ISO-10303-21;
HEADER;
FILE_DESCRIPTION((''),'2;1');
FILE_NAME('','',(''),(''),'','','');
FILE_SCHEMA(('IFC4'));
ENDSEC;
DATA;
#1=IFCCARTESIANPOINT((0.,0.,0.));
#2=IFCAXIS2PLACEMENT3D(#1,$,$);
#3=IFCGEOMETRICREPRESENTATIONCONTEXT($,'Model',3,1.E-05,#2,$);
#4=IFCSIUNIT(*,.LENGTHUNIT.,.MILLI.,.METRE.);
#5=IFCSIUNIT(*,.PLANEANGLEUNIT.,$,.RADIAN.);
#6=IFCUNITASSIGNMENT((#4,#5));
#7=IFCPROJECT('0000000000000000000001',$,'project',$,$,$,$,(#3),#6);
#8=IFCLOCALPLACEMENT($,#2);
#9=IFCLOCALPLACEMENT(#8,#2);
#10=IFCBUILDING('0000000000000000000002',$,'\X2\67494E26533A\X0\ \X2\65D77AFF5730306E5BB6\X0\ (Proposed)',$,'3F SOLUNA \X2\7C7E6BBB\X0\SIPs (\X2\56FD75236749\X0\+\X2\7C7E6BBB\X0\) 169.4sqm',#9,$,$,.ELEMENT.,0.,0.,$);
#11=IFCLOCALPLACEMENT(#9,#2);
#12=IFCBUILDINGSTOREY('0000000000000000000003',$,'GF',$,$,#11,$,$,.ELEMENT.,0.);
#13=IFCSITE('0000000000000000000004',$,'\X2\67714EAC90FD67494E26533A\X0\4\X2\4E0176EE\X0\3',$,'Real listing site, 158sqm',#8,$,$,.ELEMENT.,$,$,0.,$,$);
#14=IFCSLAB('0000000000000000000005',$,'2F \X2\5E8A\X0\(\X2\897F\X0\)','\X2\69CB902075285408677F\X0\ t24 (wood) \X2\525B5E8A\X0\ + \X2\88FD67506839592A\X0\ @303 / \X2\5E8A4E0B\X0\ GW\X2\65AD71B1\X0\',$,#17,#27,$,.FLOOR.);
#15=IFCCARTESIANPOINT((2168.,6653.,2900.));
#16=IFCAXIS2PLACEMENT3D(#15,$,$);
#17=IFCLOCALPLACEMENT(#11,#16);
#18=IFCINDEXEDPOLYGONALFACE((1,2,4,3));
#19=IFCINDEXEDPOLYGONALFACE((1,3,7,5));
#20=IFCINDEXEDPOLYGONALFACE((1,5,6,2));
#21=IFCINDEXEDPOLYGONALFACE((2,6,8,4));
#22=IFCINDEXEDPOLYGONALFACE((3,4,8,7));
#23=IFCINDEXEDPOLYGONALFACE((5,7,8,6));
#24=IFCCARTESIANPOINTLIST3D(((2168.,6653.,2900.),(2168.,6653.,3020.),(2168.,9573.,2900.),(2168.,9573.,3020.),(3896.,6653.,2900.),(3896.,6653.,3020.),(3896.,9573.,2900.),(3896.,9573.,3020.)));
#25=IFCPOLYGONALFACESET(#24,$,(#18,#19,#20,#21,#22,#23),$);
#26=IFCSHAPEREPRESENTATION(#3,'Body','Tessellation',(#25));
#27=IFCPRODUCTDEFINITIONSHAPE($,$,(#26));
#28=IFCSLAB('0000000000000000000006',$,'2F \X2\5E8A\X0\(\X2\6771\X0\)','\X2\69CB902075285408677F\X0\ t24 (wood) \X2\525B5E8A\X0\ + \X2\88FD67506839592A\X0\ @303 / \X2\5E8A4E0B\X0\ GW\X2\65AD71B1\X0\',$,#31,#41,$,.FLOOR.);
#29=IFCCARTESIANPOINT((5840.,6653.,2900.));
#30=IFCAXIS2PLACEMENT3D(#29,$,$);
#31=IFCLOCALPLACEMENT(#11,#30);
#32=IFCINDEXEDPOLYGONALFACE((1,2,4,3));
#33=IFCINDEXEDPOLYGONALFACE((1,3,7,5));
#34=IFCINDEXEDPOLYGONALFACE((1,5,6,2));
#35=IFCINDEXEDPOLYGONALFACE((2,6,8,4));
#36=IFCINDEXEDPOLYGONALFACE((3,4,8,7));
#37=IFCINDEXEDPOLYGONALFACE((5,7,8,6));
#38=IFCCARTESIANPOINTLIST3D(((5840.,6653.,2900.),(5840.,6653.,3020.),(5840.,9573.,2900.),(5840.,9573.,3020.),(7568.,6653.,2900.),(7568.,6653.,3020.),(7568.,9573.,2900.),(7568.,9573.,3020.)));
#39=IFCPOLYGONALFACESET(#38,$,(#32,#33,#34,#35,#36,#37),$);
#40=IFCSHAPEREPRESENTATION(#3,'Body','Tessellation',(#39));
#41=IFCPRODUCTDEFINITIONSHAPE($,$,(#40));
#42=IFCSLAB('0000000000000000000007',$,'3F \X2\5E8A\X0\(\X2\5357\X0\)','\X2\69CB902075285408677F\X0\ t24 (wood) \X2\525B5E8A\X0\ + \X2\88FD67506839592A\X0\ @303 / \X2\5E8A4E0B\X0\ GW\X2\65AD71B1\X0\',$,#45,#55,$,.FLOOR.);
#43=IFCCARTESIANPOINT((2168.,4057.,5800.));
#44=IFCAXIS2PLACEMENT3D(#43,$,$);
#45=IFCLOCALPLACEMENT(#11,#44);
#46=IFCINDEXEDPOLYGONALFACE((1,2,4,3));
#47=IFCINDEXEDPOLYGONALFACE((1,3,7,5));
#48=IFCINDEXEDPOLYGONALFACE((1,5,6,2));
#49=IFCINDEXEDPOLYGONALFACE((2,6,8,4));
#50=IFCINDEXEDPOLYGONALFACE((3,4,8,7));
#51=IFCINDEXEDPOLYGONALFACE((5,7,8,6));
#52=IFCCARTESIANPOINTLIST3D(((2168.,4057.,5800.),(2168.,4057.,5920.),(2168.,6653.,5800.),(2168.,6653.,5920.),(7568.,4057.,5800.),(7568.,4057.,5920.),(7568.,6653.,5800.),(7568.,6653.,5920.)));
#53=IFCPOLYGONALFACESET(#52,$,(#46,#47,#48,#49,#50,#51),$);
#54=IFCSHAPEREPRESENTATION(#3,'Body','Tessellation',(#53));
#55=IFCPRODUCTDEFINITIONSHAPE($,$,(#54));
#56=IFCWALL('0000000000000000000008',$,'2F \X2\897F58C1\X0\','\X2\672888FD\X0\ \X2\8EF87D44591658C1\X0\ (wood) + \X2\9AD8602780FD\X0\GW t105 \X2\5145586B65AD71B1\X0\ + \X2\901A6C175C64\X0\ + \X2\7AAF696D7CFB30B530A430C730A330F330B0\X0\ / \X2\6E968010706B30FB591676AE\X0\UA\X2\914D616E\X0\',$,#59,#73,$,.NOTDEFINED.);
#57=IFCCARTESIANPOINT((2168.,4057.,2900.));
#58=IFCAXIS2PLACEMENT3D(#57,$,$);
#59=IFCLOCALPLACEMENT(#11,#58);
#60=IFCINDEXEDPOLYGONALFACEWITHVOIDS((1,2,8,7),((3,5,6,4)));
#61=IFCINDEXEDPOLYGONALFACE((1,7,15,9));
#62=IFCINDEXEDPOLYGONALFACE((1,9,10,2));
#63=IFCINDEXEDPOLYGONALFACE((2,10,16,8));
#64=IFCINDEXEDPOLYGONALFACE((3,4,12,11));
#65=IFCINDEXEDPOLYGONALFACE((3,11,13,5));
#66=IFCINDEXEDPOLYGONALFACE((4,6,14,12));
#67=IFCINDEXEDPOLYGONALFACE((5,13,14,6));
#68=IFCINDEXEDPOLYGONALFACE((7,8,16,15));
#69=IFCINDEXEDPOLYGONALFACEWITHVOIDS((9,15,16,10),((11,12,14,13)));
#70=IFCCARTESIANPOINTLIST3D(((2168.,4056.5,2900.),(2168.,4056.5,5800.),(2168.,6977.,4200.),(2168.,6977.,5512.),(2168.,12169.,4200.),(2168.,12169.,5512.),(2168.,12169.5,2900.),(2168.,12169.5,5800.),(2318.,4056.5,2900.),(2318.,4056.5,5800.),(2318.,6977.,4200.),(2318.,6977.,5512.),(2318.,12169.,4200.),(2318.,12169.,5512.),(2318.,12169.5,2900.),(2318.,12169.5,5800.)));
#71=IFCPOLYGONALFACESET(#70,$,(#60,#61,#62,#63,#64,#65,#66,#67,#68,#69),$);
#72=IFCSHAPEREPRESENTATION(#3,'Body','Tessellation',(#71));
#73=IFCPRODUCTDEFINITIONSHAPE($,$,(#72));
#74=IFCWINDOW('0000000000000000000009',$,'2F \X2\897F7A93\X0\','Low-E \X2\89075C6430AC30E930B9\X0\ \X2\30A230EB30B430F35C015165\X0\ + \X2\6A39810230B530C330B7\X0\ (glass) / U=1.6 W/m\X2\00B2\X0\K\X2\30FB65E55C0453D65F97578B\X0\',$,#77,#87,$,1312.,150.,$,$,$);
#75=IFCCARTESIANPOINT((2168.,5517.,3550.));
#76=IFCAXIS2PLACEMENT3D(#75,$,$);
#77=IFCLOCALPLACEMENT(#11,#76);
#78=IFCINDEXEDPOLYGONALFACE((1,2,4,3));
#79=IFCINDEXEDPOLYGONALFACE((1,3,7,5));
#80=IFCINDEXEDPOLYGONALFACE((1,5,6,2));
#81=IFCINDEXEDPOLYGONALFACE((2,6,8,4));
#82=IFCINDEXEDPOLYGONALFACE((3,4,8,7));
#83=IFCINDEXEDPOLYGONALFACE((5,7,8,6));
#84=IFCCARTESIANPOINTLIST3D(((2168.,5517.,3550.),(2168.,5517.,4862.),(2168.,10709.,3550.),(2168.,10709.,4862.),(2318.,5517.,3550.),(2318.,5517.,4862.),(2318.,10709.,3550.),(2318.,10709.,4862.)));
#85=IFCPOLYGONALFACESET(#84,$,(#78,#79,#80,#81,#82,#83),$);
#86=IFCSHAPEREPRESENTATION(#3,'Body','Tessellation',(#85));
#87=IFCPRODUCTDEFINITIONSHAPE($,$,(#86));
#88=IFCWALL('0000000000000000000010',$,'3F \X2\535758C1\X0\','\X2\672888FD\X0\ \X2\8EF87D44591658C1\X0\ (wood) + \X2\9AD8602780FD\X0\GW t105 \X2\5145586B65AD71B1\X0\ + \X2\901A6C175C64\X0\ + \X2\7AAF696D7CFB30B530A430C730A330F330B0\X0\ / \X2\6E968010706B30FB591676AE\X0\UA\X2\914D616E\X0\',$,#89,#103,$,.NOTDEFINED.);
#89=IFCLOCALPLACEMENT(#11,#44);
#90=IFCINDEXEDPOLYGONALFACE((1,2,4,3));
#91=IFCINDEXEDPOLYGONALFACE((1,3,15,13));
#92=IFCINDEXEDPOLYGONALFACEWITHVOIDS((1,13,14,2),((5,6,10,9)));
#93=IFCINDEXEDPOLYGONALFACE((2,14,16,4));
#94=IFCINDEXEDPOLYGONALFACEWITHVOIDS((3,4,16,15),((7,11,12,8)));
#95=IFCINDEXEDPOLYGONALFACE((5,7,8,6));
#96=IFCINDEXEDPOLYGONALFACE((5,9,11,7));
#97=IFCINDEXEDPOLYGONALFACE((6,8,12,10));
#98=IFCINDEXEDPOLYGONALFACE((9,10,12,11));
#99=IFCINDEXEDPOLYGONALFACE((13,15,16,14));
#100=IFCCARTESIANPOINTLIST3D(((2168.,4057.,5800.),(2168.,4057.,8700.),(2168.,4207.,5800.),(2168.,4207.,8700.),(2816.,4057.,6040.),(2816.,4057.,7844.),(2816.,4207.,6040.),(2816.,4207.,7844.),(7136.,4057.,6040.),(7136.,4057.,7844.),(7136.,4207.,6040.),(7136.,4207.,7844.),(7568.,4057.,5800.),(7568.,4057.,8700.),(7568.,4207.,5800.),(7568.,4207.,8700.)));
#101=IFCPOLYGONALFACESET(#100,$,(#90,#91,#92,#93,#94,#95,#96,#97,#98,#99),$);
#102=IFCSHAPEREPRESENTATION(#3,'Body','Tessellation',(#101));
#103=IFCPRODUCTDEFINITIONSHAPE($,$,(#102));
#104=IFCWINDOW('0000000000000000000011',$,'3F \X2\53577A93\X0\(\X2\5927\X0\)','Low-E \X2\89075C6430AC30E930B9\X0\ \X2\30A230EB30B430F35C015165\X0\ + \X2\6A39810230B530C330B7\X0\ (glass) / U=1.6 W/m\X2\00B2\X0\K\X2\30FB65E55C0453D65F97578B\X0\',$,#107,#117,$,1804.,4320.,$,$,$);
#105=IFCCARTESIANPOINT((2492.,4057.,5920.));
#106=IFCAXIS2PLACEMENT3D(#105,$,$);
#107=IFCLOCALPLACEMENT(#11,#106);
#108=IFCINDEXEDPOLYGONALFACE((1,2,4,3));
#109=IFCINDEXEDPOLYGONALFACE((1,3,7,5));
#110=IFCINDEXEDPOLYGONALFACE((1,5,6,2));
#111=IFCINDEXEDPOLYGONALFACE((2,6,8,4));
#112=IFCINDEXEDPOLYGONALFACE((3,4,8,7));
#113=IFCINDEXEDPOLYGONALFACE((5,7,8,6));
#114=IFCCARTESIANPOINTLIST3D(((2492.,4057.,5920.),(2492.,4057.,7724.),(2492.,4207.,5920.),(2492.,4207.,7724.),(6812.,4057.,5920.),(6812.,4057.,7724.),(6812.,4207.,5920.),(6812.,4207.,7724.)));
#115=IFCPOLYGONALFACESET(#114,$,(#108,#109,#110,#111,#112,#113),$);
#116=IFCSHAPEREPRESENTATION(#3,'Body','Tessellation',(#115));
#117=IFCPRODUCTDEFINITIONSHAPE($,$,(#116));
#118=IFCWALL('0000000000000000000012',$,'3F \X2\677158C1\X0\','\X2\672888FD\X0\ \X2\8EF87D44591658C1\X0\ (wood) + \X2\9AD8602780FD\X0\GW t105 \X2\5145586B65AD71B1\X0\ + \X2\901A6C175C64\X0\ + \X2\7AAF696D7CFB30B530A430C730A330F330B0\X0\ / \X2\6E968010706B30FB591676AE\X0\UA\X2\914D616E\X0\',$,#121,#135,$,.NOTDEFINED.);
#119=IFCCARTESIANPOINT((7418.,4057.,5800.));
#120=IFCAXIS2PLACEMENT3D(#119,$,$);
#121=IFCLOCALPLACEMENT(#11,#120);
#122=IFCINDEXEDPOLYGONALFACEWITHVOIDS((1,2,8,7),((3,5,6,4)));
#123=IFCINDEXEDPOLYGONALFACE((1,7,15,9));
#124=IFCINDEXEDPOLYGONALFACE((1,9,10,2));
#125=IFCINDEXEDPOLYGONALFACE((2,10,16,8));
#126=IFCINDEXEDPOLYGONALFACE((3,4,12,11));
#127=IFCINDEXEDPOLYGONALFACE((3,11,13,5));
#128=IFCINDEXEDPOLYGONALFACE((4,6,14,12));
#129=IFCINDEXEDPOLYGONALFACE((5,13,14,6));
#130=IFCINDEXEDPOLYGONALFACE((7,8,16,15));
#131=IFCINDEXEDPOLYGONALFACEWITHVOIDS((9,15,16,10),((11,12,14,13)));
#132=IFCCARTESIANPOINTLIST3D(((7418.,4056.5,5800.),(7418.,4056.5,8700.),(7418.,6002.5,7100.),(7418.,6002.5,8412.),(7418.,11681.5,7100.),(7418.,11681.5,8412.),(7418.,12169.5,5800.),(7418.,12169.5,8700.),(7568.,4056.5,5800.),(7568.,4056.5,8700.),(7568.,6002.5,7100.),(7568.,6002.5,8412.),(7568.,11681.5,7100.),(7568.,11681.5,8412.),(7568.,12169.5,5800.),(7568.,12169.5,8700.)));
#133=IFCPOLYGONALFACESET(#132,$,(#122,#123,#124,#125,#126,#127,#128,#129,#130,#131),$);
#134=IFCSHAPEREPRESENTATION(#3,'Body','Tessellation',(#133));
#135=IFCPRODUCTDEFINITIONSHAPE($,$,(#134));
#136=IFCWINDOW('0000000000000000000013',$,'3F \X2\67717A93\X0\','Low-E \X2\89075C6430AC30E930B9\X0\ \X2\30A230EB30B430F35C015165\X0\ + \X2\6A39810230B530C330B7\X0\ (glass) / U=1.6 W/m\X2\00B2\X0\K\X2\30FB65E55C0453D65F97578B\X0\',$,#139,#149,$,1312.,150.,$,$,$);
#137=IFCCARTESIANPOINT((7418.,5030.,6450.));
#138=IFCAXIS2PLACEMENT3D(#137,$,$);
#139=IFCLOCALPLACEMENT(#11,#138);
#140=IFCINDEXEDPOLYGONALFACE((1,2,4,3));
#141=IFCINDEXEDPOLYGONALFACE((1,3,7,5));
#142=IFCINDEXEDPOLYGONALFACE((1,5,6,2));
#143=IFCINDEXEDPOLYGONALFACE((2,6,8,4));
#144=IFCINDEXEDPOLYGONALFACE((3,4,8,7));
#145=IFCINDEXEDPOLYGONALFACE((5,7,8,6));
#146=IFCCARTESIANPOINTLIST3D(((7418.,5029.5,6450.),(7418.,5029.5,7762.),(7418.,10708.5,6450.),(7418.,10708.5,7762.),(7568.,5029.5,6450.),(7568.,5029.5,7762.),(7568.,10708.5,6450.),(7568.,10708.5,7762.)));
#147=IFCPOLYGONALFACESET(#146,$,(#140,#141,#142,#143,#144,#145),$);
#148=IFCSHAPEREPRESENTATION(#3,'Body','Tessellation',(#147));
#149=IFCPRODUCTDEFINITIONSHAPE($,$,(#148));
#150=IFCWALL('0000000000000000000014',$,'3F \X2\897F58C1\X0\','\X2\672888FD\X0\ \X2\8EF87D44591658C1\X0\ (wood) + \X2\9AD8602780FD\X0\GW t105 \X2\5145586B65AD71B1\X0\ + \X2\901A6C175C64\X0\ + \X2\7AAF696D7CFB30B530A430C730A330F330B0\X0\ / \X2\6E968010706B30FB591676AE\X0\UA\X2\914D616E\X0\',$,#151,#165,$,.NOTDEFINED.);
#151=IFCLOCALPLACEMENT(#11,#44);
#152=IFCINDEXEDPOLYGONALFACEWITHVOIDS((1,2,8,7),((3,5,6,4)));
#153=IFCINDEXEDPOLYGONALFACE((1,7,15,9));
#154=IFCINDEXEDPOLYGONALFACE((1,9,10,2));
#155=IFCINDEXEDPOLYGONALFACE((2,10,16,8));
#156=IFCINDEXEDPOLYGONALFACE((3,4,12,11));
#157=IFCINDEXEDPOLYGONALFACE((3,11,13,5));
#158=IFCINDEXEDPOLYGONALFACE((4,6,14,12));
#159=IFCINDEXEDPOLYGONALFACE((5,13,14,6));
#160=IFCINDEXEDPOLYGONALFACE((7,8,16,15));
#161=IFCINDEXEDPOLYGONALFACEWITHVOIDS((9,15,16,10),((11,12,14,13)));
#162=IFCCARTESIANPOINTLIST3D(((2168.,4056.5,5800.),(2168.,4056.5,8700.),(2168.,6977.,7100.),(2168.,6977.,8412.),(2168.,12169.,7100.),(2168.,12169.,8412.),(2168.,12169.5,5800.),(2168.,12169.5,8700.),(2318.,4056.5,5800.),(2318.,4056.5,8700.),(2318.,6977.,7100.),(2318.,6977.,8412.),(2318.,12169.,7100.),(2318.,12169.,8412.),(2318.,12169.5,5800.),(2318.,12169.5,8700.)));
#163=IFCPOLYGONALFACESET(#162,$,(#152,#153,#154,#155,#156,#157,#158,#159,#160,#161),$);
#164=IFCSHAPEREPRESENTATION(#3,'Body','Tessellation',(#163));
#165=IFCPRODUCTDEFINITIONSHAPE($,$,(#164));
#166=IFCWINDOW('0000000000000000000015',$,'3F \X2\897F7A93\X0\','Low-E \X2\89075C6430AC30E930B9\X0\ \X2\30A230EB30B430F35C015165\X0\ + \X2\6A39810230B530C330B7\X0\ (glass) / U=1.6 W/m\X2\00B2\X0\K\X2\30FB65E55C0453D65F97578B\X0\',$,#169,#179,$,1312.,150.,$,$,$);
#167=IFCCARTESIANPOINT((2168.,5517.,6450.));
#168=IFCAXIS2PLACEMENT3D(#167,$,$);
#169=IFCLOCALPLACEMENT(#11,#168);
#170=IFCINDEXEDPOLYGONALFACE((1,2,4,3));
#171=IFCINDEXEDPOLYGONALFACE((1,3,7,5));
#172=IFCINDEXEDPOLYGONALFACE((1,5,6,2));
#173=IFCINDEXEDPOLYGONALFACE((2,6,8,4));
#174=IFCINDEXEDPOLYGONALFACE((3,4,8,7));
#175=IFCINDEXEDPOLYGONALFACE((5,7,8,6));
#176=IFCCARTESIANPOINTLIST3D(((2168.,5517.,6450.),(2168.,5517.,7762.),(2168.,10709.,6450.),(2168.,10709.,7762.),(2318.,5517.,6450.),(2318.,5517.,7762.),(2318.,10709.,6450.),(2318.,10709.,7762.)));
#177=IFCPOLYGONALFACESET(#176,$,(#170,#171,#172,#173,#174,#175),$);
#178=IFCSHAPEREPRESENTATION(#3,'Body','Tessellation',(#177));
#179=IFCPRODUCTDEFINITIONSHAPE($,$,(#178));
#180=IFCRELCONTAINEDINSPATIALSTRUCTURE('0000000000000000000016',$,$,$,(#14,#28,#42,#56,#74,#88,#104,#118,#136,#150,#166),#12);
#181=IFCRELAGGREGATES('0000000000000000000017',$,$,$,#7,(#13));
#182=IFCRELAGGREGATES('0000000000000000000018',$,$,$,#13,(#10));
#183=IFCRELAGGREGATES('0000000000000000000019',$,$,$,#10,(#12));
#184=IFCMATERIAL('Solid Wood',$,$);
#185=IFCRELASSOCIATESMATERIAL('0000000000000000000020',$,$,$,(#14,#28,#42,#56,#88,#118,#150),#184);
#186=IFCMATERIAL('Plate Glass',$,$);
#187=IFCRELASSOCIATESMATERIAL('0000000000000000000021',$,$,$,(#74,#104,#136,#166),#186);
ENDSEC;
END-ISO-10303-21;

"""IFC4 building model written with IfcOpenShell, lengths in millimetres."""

from ifc_helpers import new_model, si_unit, frame, frame_2d, origin, place, context, project, spatial, rectangle, extrude, material, element, fill, save


model = new_model("IFC4")

# Units and contexts
model_context = context("Model", 3, precision=1e-05, world=origin())
ifc_project = project(units=[si_unit("LENGTHUNIT", "METRE", prefix="MILLI"), si_unit("PLANEANGLEUNIT", "RADIAN")], contexts=[model_context])

# Site, building, storey
site_placement = place(None, origin())
site = spatial("IfcSite", under=ifc_project, at=site_placement, Name="東京都杉並区4丁目3", ObjectType="Real listing site, 158sqm", CompositionType="ELEMENT", RefElevation=0.0)
building_placement = place(site_placement, origin())
building = spatial("IfcBuilding", under=site, at=building_placement, Name="杉並区 旗竿地の家 (Proposed)", ObjectType="3F SOLUNA 籾殻SIPs (国産杉+籾殻) 169.4sqm", CompositionType="ELEMENT", ElevationOfRefHeight=0.0, ElevationOfTerrain=0.0)
storey_placement = place(building_placement, origin())
storey = spatial("IfcBuildingStorey", under=building, at=storey_placement, Name="GF", CompositionType="ELEMENT", Elevation=0.0)

# Slabs
ifc_material_1 = material(Name="Solid Wood")
slab_1_placement = place(storey_placement, frame((2168.0, 6653.0, 2900.0)))
element("IfcSlab", 1, at=slab_1_placement, inside=storey, material=ifc_material_1, Name="2F 床(西)", Description="構造用合板 t24 (wood) 剛床 + 製材根太 @303 / 床下 GW断熱", PredefinedType="FLOOR", context=model_context, shape_type="SweptSolid", body=[
    extrude(rectangle(XDim=1728.0, YDim=2920.0, at=frame_2d((864.0, 1460.0))), frame((2168.0, 6653.0, 2900.0)), (0.0, 0.0, 1.0), 120.0),
])
slab_2_placement = place(storey_placement, frame((5840.0, 6653.0, 2900.0)))
element("IfcSlab", 2, at=slab_2_placement, inside=storey, material=ifc_material_1, Name="2F 床(東)", Description="構造用合板 t24 (wood) 剛床 + 製材根太 @303 / 床下 GW断熱", PredefinedType="FLOOR", context=model_context, shape_type="SweptSolid", body=[
    extrude(rectangle(XDim=1728.0, YDim=2920.0, at=frame_2d((864.0, 1460.0))), frame((5840.0, 6653.0, 2900.0)), (0.0, 0.0, 1.0), 120.0),
])
slab_3_placement = place(storey_placement, frame((2168.0, 4057.0, 5800.0)))
element("IfcSlab", 3, at=slab_3_placement, inside=storey, material=ifc_material_1, Name="3F 床(南)", Description="構造用合板 t24 (wood) 剛床 + 製材根太 @303 / 床下 GW断熱", PredefinedType="FLOOR", context=model_context, shape_type="SweptSolid", body=[
    extrude(rectangle(XDim=5400.0, YDim=2596.0, at=frame_2d((2700.0, 1298.0))), frame((2168.0, 4057.0, 5800.0)), (0.0, 0.0, 1.0), 120.0),
])

# Walls, openings, windows
wall_1_placement = place(storey_placement, frame((2168.0, 4057.0, 2900.0)))
wall_1 = element("IfcWall", 4, at=wall_1_placement, inside=storey, material=ifc_material_1, Name="2F 西壁", Description="木製 軸組外壁 (wood) + 高性能GW t105 充填断熱 + 通気層 + 窯業系サイディング / 準耐火・外皮UA配慮", PredefinedType="NOTDEFINED", context=model_context, shape_type="SweptSolid", body=[
    extrude(rectangle(XDim=150.0, YDim=8113.0, at=frame_2d((75.0, 4056.0))), frame((2168.0, 4057.0, 2900.0)), (0.0, 0.0, 1.0), 2900.0),
])
opening_1_placement = place(storey_placement, frame((2168.0, 5517.0, 3550.0)))
opening_1 = element("IfcOpeningElement", 5, at=opening_1_placement, cuts=wall_1, PredefinedType="NOTDEFINED", context=model_context, shape_type="SweptSolid", body=[
    extrude(rectangle(XDim=150.0, YDim=5192.0, at=frame_2d((75.0, 2596.0))), frame((2168.0, 5517.0, 3550.0)), (0.0, 0.0, 1.0), 1312.0),
])
ifc_material_2 = material(Name="Plate Glass")
window_1_placement = place(storey_placement, frame((2168.0, 5517.0, 3550.0)))
window_1 = element("IfcWindow", 6, at=window_1_placement, inside=storey, material=ifc_material_2, Name="2F 西窓", Description="Low-E 複層ガラス アルゴン封入 + 樹脂サッシ (glass) / U=1.6 W/m²K・日射取得型", OverallHeight=1312.0, OverallWidth=150.0, context=model_context, shape_type="SweptSolid", body=[
    extrude(rectangle(XDim=150.0, YDim=5192.0, at=frame_2d((75.0, 2596.0))), frame((2168.0, 5517.0, 3550.0)), (0.0, 0.0, 1.0), 1312.0),
])
fill(opening_1, window_1)
wall_2_placement = place(storey_placement, frame((2168.0, 4057.0, 5800.0)))
wall_2 = element("IfcWall", 7, at=wall_2_placement, inside=storey, material=ifc_material_1, Name="3F 南壁", Description="木製 軸組外壁 (wood) + 高性能GW t105 充填断熱 + 通気層 + 窯業系サイディング / 準耐火・外皮UA配慮", PredefinedType="NOTDEFINED", context=model_context, shape_type="SweptSolid", body=[
    extrude(rectangle(XDim=5400.0, YDim=150.0, at=frame_2d((2700.0, 75.0))), frame((2168.0, 4057.0, 5800.0)), (0.0, 0.0, 1.0), 2900.0),
])
opening_2_placement = place(storey_placement, frame((2492.0, 4057.0, 5920.0)))
opening_2 = element("IfcOpeningElement", 8, at=opening_2_placement, cuts=wall_2, PredefinedType="NOTDEFINED", context=model_context, shape_type="SweptSolid", body=[
    extrude(rectangle(XDim=4320.0, YDim=150.0, at=frame_2d((2160.0, 75.0))), frame((2492.0, 4057.0, 5920.0)), (0.0, 0.0, 1.0), 1804.0),
])
window_2_placement = place(storey_placement, frame((2492.0, 4057.0, 5920.0)))
window_2 = element("IfcWindow", 9, at=window_2_placement, inside=storey, material=ifc_material_2, Name="3F 南窓(大)", Description="Low-E 複層ガラス アルゴン封入 + 樹脂サッシ (glass) / U=1.6 W/m²K・日射取得型", OverallHeight=1804.0, OverallWidth=4320.0, context=model_context, shape_type="SweptSolid", body=[
    extrude(rectangle(XDim=4320.0, YDim=150.0, at=frame_2d((2160.0, 75.0))), frame((2492.0, 4057.0, 5920.0)), (0.0, 0.0, 1.0), 1804.0),
])
fill(opening_2, window_2)
wall_3_placement = place(storey_placement, frame((7418.0, 4057.0, 5800.0)))
wall_3 = element("IfcWall", 10, at=wall_3_placement, inside=storey, material=ifc_material_1, Name="3F 東壁", Description="木製 軸組外壁 (wood) + 高性能GW t105 充填断熱 + 通気層 + 窯業系サイディング / 準耐火・外皮UA配慮", PredefinedType="NOTDEFINED", context=model_context, shape_type="SweptSolid", body=[
    extrude(rectangle(XDim=150.0, YDim=8113.0, at=frame_2d((75.0, 4056.0))), frame((7418.0, 4057.0, 5800.0)), (0.0, 0.0, 1.0), 2900.0),
])
opening_3_placement = place(storey_placement, frame((7418.0, 5030.0, 6450.0)))
opening_3 = element("IfcOpeningElement", 11, at=opening_3_placement, cuts=wall_3, PredefinedType="NOTDEFINED", context=model_context, shape_type="SweptSolid", body=[
    extrude(rectangle(XDim=150.0, YDim=5679.0, at=frame_2d((75.0, 2839.0))), frame((7418.0, 5030.0, 6450.0)), (0.0, 0.0, 1.0), 1312.0),
])
window_3_placement = place(storey_placement, frame((7418.0, 5030.0, 6450.0)))
window_3 = element("IfcWindow", 12, at=window_3_placement, inside=storey, material=ifc_material_2, Name="3F 東窓", Description="Low-E 複層ガラス アルゴン封入 + 樹脂サッシ (glass) / U=1.6 W/m²K・日射取得型", OverallHeight=1312.0, OverallWidth=150.0, context=model_context, shape_type="SweptSolid", body=[
    extrude(rectangle(XDim=150.0, YDim=5679.0, at=frame_2d((75.0, 2839.0))), frame((7418.0, 5030.0, 6450.0)), (0.0, 0.0, 1.0), 1312.0),
])
fill(opening_3, window_3)
wall_4_placement = place(storey_placement, frame((2168.0, 4057.0, 5800.0)))
wall_4 = element("IfcWall", 13, at=wall_4_placement, inside=storey, material=ifc_material_1, Name="3F 西壁", Description="木製 軸組外壁 (wood) + 高性能GW t105 充填断熱 + 通気層 + 窯業系サイディング / 準耐火・外皮UA配慮", PredefinedType="NOTDEFINED", context=model_context, shape_type="SweptSolid", body=[
    extrude(rectangle(XDim=150.0, YDim=8113.0, at=frame_2d((75.0, 4056.0))), frame((2168.0, 4057.0, 5800.0)), (0.0, 0.0, 1.0), 2900.0),
])
opening_4_placement = place(storey_placement, frame((2168.0, 5517.0, 6450.0)))
opening_4 = element("IfcOpeningElement", 14, at=opening_4_placement, cuts=wall_4, PredefinedType="NOTDEFINED", context=model_context, shape_type="SweptSolid", body=[
    extrude(rectangle(XDim=150.0, YDim=5192.0, at=frame_2d((75.0, 2596.0))), frame((2168.0, 5517.0, 6450.0)), (0.0, 0.0, 1.0), 1312.0),
])
window_4_placement = place(storey_placement, frame((2168.0, 5517.0, 6450.0)))
window_4 = element("IfcWindow", 15, at=window_4_placement, inside=storey, material=ifc_material_2, Name="3F 西窓", Description="Low-E 複層ガラス アルゴン封入 + 樹脂サッシ (glass) / U=1.6 W/m²K・日射取得型", OverallHeight=1312.0, OverallWidth=150.0, context=model_context, shape_type="SweptSolid", body=[
    extrude(rectangle(XDim=150.0, YDim=5192.0, at=frame_2d((75.0, 2596.0))), frame((2168.0, 5517.0, 6450.0)), (0.0, 0.0, 1.0), 1312.0),
])
fill(opening_4, window_4)

save(model, "model.ifc")
